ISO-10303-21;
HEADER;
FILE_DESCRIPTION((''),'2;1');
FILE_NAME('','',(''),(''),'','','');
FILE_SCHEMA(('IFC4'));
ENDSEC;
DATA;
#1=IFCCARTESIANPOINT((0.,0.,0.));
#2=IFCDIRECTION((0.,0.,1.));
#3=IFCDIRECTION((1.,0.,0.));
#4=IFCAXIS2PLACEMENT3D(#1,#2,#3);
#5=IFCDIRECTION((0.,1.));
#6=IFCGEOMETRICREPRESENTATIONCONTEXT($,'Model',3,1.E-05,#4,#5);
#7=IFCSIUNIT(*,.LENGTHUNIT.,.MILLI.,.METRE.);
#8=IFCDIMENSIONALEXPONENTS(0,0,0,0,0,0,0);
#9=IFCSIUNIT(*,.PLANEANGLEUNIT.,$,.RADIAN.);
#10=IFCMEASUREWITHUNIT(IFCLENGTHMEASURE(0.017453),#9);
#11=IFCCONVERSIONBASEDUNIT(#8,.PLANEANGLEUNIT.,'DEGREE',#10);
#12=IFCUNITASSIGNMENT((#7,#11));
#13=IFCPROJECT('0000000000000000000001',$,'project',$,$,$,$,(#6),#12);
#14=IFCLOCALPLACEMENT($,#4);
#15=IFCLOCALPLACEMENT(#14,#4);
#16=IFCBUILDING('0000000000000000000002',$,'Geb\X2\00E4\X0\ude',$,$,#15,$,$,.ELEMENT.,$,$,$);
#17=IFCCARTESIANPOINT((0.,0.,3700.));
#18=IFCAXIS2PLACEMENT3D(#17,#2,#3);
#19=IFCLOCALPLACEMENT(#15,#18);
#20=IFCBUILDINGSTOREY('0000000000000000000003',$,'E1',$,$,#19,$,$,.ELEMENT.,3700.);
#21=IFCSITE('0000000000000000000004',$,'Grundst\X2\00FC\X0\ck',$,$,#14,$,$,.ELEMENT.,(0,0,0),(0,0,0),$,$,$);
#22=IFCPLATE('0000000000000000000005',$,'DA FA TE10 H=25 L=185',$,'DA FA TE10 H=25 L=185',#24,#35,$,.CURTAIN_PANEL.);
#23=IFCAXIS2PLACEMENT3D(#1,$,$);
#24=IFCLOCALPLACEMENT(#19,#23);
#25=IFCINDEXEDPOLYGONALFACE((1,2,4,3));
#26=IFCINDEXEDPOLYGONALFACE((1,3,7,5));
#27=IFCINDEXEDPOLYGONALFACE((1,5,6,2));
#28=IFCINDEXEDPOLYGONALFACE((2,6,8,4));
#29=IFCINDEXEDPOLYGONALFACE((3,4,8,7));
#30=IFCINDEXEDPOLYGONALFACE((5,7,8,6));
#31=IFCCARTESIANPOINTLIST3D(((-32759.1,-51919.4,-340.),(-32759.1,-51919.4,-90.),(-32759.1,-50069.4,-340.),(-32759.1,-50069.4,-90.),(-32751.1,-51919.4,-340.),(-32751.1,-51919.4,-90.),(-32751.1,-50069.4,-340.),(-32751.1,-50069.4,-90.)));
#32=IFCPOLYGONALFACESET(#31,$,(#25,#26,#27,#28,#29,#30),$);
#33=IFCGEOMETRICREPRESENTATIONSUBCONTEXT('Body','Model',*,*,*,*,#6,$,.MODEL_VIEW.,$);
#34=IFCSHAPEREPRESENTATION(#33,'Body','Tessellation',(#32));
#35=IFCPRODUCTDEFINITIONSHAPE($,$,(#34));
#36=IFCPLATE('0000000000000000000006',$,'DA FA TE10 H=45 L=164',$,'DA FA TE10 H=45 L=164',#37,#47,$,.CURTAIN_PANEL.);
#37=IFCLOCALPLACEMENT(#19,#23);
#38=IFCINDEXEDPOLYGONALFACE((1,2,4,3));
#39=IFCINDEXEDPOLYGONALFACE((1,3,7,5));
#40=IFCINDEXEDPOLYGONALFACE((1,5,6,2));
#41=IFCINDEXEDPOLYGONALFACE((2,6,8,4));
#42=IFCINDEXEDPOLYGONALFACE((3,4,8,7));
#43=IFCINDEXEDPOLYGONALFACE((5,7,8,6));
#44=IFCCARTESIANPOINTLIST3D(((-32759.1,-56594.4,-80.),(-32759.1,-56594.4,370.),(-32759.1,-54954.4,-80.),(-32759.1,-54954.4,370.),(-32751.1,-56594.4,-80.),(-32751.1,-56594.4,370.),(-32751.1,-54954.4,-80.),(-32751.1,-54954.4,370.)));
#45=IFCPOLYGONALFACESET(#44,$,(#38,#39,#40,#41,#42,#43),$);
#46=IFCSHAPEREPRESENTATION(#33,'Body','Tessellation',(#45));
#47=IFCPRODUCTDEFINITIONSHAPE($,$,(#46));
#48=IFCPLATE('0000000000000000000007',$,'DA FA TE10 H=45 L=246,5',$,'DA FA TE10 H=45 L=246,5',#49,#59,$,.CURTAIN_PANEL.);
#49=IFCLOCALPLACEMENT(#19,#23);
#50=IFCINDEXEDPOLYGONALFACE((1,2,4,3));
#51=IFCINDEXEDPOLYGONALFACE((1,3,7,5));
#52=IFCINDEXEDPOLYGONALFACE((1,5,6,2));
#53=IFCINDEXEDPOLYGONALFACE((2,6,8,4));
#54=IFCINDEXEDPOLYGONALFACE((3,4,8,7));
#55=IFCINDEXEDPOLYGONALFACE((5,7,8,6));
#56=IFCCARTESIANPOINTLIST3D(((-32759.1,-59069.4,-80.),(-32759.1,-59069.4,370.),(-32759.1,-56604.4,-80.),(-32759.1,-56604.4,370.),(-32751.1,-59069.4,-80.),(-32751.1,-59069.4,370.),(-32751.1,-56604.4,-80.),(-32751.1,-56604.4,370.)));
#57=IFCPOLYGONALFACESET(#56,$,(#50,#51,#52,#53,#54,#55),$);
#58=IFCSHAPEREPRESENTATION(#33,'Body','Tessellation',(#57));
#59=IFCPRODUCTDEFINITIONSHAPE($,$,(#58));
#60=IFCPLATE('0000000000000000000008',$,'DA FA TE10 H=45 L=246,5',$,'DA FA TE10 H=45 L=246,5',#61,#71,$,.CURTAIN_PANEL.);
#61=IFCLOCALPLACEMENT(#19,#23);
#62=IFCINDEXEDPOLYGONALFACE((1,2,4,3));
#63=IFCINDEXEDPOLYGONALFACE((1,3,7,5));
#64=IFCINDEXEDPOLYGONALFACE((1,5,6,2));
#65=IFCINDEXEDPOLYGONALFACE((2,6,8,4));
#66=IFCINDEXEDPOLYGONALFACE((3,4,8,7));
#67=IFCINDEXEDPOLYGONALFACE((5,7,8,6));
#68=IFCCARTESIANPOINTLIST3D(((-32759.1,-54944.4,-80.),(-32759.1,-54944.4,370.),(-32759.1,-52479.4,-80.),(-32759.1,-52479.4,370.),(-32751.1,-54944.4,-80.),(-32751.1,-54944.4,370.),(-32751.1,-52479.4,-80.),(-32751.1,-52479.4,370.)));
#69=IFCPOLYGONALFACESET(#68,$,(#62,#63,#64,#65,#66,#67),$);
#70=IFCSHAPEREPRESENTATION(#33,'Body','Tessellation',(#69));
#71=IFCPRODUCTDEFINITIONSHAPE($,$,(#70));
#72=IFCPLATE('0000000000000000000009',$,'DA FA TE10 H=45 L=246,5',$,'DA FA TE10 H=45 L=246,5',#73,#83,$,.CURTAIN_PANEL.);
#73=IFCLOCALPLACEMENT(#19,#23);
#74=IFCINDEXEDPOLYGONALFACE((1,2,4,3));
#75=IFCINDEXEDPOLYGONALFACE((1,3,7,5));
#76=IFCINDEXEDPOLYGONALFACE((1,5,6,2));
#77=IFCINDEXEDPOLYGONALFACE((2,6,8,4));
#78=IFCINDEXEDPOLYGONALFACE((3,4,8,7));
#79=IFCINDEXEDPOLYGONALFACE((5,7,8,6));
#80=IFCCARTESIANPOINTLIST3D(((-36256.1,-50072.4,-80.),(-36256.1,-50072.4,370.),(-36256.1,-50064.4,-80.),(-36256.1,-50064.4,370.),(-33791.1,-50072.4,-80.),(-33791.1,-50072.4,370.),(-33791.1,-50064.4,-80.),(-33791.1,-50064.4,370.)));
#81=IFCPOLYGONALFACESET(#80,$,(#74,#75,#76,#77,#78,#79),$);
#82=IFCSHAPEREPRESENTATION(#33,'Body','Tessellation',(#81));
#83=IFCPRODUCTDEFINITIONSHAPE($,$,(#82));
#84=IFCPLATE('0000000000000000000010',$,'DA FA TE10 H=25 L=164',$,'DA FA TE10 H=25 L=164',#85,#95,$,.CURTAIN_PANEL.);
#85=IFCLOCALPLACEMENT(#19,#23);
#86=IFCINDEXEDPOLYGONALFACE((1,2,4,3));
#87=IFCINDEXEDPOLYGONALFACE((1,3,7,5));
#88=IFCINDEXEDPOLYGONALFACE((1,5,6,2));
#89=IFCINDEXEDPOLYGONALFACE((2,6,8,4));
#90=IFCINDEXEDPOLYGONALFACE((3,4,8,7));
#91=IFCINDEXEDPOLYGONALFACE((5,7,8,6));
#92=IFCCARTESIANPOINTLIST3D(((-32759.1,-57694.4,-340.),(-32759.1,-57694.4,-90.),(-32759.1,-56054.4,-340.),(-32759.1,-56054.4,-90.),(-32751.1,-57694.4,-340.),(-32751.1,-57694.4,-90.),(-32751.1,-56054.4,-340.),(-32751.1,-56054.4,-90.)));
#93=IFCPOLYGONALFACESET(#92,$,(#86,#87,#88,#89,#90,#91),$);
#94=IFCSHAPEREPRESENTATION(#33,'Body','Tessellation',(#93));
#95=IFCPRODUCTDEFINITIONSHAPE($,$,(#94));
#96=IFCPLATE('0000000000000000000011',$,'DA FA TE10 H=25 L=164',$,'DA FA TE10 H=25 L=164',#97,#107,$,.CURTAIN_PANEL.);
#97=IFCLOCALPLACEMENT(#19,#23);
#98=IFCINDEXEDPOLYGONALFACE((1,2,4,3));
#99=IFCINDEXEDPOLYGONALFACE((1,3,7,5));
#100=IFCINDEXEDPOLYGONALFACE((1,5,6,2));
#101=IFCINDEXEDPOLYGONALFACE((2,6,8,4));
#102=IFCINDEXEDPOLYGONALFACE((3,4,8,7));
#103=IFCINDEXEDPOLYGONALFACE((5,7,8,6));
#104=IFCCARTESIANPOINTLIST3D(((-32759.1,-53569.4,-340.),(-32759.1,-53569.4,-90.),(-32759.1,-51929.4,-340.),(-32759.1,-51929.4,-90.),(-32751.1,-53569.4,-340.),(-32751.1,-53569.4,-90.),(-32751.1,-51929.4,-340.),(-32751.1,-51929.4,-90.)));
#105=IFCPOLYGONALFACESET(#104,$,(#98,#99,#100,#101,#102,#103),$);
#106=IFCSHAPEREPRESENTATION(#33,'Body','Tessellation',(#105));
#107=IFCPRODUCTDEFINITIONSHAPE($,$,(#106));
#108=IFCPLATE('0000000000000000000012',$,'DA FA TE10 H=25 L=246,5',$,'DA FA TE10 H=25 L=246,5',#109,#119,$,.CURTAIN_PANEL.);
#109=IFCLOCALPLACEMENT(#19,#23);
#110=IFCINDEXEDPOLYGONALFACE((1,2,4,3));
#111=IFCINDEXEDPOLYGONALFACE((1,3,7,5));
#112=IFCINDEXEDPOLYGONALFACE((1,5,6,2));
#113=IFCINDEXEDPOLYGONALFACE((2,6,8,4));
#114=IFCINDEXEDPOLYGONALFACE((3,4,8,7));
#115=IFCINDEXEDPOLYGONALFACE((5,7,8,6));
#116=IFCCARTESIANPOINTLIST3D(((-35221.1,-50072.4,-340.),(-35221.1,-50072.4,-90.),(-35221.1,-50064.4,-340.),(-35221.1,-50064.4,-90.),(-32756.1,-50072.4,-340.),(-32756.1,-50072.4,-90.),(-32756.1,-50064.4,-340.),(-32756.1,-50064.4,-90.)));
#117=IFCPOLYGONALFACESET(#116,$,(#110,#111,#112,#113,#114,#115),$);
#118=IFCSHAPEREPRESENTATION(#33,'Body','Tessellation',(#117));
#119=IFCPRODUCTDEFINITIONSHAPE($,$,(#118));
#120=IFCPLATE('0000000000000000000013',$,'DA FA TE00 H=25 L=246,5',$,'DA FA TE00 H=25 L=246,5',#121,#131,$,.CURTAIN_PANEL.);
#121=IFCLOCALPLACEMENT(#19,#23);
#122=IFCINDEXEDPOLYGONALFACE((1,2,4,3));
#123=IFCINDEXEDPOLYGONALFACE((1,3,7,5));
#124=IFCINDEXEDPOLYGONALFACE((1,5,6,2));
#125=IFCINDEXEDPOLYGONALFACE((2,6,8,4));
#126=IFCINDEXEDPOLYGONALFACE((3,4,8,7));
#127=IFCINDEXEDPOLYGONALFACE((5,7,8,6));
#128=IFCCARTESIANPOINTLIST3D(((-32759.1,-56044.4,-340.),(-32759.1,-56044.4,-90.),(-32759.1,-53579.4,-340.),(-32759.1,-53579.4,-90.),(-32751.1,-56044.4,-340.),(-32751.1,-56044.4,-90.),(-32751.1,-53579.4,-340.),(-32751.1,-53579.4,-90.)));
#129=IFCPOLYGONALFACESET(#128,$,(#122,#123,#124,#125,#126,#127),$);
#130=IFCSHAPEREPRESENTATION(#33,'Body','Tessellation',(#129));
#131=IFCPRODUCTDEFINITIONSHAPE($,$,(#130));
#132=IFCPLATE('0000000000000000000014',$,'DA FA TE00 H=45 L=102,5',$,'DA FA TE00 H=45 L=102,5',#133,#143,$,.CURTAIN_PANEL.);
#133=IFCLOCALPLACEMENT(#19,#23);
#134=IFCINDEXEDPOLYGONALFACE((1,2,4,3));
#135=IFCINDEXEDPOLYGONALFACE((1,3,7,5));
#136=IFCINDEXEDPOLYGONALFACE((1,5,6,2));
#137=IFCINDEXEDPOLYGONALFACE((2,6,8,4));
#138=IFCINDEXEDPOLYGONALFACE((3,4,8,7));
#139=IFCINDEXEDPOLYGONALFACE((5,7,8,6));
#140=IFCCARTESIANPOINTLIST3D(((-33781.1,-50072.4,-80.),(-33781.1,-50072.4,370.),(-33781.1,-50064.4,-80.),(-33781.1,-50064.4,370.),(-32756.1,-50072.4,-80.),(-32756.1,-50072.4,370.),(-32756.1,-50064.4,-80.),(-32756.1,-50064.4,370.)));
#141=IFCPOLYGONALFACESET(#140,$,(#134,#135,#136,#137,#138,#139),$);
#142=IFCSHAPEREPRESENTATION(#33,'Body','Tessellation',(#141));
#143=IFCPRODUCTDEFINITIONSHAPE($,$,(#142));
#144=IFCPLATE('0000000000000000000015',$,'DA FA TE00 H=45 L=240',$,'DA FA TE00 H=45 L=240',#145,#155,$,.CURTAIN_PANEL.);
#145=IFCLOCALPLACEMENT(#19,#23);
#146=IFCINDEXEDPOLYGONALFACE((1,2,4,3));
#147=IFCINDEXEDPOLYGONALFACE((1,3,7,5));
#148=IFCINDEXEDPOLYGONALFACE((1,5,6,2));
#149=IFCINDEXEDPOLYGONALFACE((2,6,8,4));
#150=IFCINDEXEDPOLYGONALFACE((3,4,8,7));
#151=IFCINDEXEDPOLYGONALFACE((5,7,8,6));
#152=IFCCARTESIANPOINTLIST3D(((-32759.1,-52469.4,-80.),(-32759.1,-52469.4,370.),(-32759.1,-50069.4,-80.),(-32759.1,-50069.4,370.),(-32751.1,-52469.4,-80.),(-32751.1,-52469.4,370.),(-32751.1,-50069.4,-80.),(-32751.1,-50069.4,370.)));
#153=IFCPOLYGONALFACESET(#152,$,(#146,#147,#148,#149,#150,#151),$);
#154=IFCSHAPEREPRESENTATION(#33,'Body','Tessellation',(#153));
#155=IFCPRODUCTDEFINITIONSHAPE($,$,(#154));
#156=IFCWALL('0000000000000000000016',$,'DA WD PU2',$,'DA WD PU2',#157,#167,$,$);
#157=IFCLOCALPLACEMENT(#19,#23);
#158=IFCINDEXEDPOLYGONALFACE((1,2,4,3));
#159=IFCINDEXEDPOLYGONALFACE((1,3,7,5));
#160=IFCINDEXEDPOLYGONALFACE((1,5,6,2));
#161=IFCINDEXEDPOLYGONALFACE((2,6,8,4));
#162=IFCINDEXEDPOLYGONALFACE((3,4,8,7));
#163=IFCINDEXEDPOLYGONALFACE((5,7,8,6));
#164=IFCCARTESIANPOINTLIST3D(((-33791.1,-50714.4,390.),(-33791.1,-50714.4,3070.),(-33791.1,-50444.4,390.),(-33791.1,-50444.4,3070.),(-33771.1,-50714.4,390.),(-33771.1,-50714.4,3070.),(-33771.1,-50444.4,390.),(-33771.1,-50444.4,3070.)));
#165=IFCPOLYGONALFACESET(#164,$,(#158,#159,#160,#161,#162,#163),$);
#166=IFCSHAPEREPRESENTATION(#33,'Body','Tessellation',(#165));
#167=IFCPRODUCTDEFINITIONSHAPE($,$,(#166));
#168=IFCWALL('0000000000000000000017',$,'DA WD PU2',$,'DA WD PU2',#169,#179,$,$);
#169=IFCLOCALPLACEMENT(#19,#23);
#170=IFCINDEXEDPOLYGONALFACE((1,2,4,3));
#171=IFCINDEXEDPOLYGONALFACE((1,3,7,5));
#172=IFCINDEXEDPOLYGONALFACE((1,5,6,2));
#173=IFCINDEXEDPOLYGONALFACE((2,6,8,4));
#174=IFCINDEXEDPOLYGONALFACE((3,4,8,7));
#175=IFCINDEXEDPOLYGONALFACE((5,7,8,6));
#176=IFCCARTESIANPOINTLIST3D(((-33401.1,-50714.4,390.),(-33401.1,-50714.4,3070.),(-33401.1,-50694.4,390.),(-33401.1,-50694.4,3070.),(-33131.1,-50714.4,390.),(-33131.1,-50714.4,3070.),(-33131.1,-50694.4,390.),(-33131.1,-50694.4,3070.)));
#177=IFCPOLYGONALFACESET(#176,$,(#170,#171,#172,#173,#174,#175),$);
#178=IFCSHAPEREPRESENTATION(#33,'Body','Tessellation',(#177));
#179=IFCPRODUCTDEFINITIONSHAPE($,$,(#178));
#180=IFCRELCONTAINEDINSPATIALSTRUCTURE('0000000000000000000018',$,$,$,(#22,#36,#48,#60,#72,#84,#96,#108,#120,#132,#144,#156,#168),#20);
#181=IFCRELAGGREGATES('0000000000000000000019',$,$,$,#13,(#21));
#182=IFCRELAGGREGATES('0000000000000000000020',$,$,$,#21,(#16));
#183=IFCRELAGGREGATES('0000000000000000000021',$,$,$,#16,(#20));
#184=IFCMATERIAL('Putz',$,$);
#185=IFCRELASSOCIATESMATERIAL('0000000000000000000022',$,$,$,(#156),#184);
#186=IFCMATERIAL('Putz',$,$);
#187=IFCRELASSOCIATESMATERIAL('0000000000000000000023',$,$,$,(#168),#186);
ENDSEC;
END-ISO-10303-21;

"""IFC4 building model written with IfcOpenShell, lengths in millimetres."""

from ifc_helpers import new_model, entity, si_unit, converted_unit, direction, frame, origin_with_axes, place, context, subcontext, project, spatial, line, indexed_curve, outline, extrude, source, transform, mapped, material, element, save


model = new_model("IFC4")

# Units and contexts
model_context = context("Model", 3, precision=1e-05, world=origin_with_axes(), true_north=direction((0.0, 1.0)))
body_context = subcontext(model_context, "Body", "Model", "MODEL_VIEW")
ifc_project = project(units=[si_unit("LENGTHUNIT", "METRE", prefix="MILLI"), converted_unit("PLANEANGLEUNIT", "DEGREE", entity("IfcLengthMeasure", 0.017453), si_unit("PLANEANGLEUNIT", "RADIAN"), dimensions=[0, 0, 0, 0, 0, 0, 0])], contexts=[model_context])

# Site, building, storey
site_placement = place(None, origin_with_axes())
site = spatial("IfcSite", under=ifc_project, at=site_placement, Name="Grundstück", CompositionType="ELEMENT", RefLatitude=(0, 0, 0), RefLongitude=(0, 0, 0))
building_placement = place(site_placement, origin_with_axes())
building = spatial("IfcBuilding", under=site, at=building_placement, Name="Gebäude", CompositionType="ELEMENT")
storey_placement = place(building_placement, frame((0.0, 0.0, 3700.0), z_axis=(0.0, 0.0, 1.0), x_axis=(1.0, 0.0, 0.0)))
storey = spatial("IfcBuildingStorey", under=building, at=storey_placement, Name="E1", CompositionType="ELEMENT", Elevation=3700.0)

# Plates
shared_shape_1 = source(origin_with_axes(), body_context, "Body", "SweptSolid", [
    extrude(outline(indexed_curve([(-925.0, 0.0), (925.0, 0.0), (925.0, 8.0), (-925.0, 8.0)], segments=[line(1, 2), line(2, 3), line(3, 4), line(4, 1)])), frame((0.0, 0.0, 250.0), z_axis=(0.0, 0.0, 1.0), x_axis=(1.0, 0.0, 0.0)), (0.0, 0.0, -1.0), 250.0),
])
plate_1_placement = place(storey_placement, frame((-32751.1, -50994.4, -340.0), z_axis=(0.0, 0.0, 1.0), x_axis=(0.0, 1.0, 0.0)))
element("IfcPlate", 1, at=plate_1_placement, inside=storey, Name="DA FA TE10 H=25 L=185", ObjectType="DA FA TE10 H=25 L=185", PredefinedType="CURTAIN_PANEL", context=body_context, shape_type="MappedRepresentation", body=[
    mapped(shared_shape_1, transform((0.0, 0.0, 0.0), x_axis=(1.0, 0.0, 0.0), y_axis=(0.0, 1.0, 0.0), z_axis=(0.0, 0.0, 1.0), scale=1.0)),
])
shared_shape_2 = source(origin_with_axes(), body_context, "Body", "SweptSolid", [
    extrude(outline(indexed_curve([(-820.0, 0.0), (820.0, 0.0), (820.0, 8.0), (-820.0, 8.0)], segments=[line(1, 2), line(2, 3), line(3, 4), line(4, 1)])), frame((0.0, 0.0, 450.0), z_axis=(0.0, 0.0, 1.0), x_axis=(1.0, 0.0, 0.0)), (0.0, 0.0, -1.0), 450.0),
])
plate_2_placement = place(storey_placement, frame((-32751.1, -55774.4, -80.0), z_axis=(0.0, 0.0, 1.0), x_axis=(0.0, 1.0, 0.0)))
element("IfcPlate", 2, at=plate_2_placement, inside=storey, Name="DA FA TE10 H=45 L=164", ObjectType="DA FA TE10 H=45 L=164", PredefinedType="CURTAIN_PANEL", context=body_context, shape_type="MappedRepresentation", body=[
    mapped(shared_shape_2, transform((0.0, 0.0, 0.0), x_axis=(1.0, 0.0, 0.0), y_axis=(0.0, 1.0, 0.0), z_axis=(0.0, 0.0, 1.0), scale=1.0)),
])
shared_shape_3 = source(origin_with_axes(), body_context, "Body", "SweptSolid", [
    extrude(outline(indexed_curve([(-1232.5, 0.0), (1232.5, 0.0), (1232.5, 8.0), (-1232.5, 8.0)], segments=[line(1, 2), line(2, 3), line(3, 4), line(4, 1)])), frame((0.0, 0.0, 450.0), z_axis=(0.0, 0.0, 1.0), x_axis=(1.0, 0.0, 0.0)), (0.0, 0.0, -1.0), 450.0),
])
for number, where, z_axis, x_axis, name in (
    (3, (-32751.1, -57836.9, -80.0), (0.0, 0.0, 1.0), (0.0, 1.0, 0.0), "DA FA TE10 H=45 L=246,5"),
    (4, (-32751.1, -53711.9, -80.0), (0.0, 0.0, 1.0), (0.0, 1.0, 0.0), "DA FA TE10 H=45 L=246,5"),
    (5, (-35023.6, -50064.4, -80.0), (0.0, 0.0, 1.0), (-1.0, 0.0, 0.0), "DA FA TE10 H=45 L=246,5"),
):
    element("IfcPlate", number, at=place(storey_placement, frame(where, z_axis=z_axis, x_axis=x_axis)), inside=storey, Name=name, ObjectType="DA FA TE10 H=45 L=246,5", PredefinedType="CURTAIN_PANEL", context=body_context, shape_type="MappedRepresentation", body=[
        mapped(shared_shape_3, transform((0.0, 0.0, 0.0), x_axis=(1.0, 0.0, 0.0), y_axis=(0.0, 1.0, 0.0), z_axis=(0.0, 0.0, 1.0), scale=1.0)),
    ])
shared_shape_4 = source(origin_with_axes(), body_context, "Body", "SweptSolid", [
    extrude(outline(indexed_curve([(-820.0, 0.0), (820.0, 0.0), (820.0, 8.0), (-820.0, 8.0)], segments=[line(1, 2), line(2, 3), line(3, 4), line(4, 1)])), frame((0.0, 0.0, 250.0), z_axis=(0.0, 0.0, 1.0), x_axis=(1.0, 0.0, 0.0)), (0.0, 0.0, -1.0), 250.0),
])
for number, where, z_axis, x_axis, name in (
    (6, (-32751.1, -56874.4, -340.0), (0.0, 0.0, 1.0), (0.0, 1.0, 0.0), "DA FA TE10 H=25 L=164"),
    (7, (-32751.1, -52749.4, -340.0), (0.0, 0.0, 1.0), (0.0, 1.0, 0.0), "DA FA TE10 H=25 L=164"),
):
    element("IfcPlate", number, at=place(storey_placement, frame(where, z_axis=z_axis, x_axis=x_axis)), inside=storey, Name=name, ObjectType="DA FA TE10 H=25 L=164", PredefinedType="CURTAIN_PANEL", context=body_context, shape_type="MappedRepresentation", body=[
        mapped(shared_shape_4, transform((0.0, 0.0, 0.0), x_axis=(1.0, 0.0, 0.0), y_axis=(0.0, 1.0, 0.0), z_axis=(0.0, 0.0, 1.0), scale=1.0)),
    ])
shared_shape_5 = source(origin_with_axes(), body_context, "Body", "SweptSolid", [
    extrude(outline(indexed_curve([(-1232.5, 0.0), (1232.5, 0.0), (1232.5, 8.0), (-1232.5, 8.0)], segments=[line(1, 2), line(2, 3), line(3, 4), line(4, 1)])), frame((0.0, 0.0, 250.0), z_axis=(0.0, 0.0, 1.0), x_axis=(1.0, 0.0, 0.0)), (0.0, 0.0, -1.0), 250.0),
])
plate_3_placement = place(storey_placement, frame((-33988.6, -50064.4, -340.0), z_axis=(0.0, 0.0, 1.0), x_axis=(-1.0, 0.0, 0.0)))
element("IfcPlate", 8, at=plate_3_placement, inside=storey, Name="DA FA TE10 H=25 L=246,5", ObjectType="DA FA TE10 H=25 L=246,5", PredefinedType="CURTAIN_PANEL", context=body_context, shape_type="MappedRepresentation", body=[
    mapped(shared_shape_5, transform((0.0, 0.0, 0.0), x_axis=(1.0, 0.0, 0.0), y_axis=(0.0, 1.0, 0.0), z_axis=(0.0, 0.0, 1.0), scale=1.0)),
])
shared_shape_6 = source(origin_with_axes(), body_context, "Body", "SweptSolid", [
    extrude(outline(indexed_curve([(-1232.5, 0.0), (1232.5, 0.0), (1232.5, 8.0), (-1232.5, 8.0)], segments=[line(1, 2), line(2, 3), line(3, 4), line(4, 1)])), frame((0.0, 0.0, 250.0), z_axis=(0.0, 0.0, 1.0), x_axis=(1.0, 0.0, 0.0)), (0.0, 0.0, -1.0), 250.0),
])
plate_4_placement = place(storey_placement, frame((-32751.1, -54811.9, -340.0), z_axis=(0.0, 0.0, 1.0), x_axis=(0.0, 1.0, 0.0)))
element("IfcPlate", 9, at=plate_4_placement, inside=storey, Name="DA FA TE00 H=25 L=246,5", ObjectType="DA FA TE00 H=25 L=246,5", PredefinedType="CURTAIN_PANEL", context=body_context, shape_type="MappedRepresentation", body=[
    mapped(shared_shape_6, transform((0.0, 0.0, 0.0), x_axis=(1.0, 0.0, 0.0), y_axis=(0.0, 1.0, 0.0), z_axis=(0.0, 0.0, 1.0), scale=1.0)),
])
shared_shape_7 = source(origin_with_axes(), body_context, "Body", "SweptSolid", [
    extrude(outline(indexed_curve([(-512.5, 0.0), (512.5, 0.0), (512.5, 8.0), (-512.5, 8.0)], segments=[line(1, 2), line(2, 3), line(3, 4), line(4, 1)])), frame((0.0, 0.0, 450.0), z_axis=(0.0, 0.0, 1.0), x_axis=(1.0, 0.0, 0.0)), (0.0, 0.0, -1.0), 450.0),
])
plate_5_placement = place(storey_placement, frame((-33268.6, -50064.4, -80.0), z_axis=(0.0, 0.0, 1.0), x_axis=(-1.0, 0.0, 0.0)))
element("IfcPlate", 10, at=plate_5_placement, inside=storey, Name="DA FA TE00 H=45 L=102,5", ObjectType="DA FA TE00 H=45 L=102,5", PredefinedType="CURTAIN_PANEL", context=body_context, shape_type="MappedRepresentation", body=[
    mapped(shared_shape_7, transform((0.0, 0.0, 0.0), x_axis=(1.0, 0.0, 0.0), y_axis=(0.0, 1.0, 0.0), z_axis=(0.0, 0.0, 1.0), scale=1.0)),
])
plate_6_placement = place(storey_placement, frame((-32751.1, -51269.4, -80.0), z_axis=(0.0, 0.0, 1.0), x_axis=(0.0, 1.0, 0.0)))
element("IfcPlate", 11, at=plate_6_placement, inside=storey, Name="DA FA TE00 H=45 L=240", ObjectType="DA FA TE00 H=45 L=240", PredefinedType="CURTAIN_PANEL", context=body_context, shape_type="SweptSolid", body=[
    extrude(outline(indexed_curve([(-1200.0, 0.0), (1200.0, 0.0), (1200.0, 8.0), (-1200.0, 8.0)], segments=[line(1, 2), line(2, 3), line(3, 4), line(4, 1)])), frame((0.0, 0.0, 450.0), z_axis=(0.0, 0.0, 1.0), x_axis=(1.0, 0.0, 0.0)), (0.0, 0.0, -1.0), 450.0),
])

# Walls
ifc_material_1 = material(Name="Putz")
wall_1_placement = place(storey_placement, frame((-33781.1, -50444.4, 390.0), z_axis=(0.0, 0.0, 1.0), x_axis=(0.0, -1.0, 0.0)))
element("IfcWall", 12, at=wall_1_placement, inside=storey, material=ifc_material_1, Name="DA WD PU2", ObjectType="DA WD PU2", context=body_context, shape_type="SweptSolid", body=[
    extrude(outline(indexed_curve([(0.0, -10.0), (0.0, 10.0), (270.0, 10.0), (270.0, -10.0)], segments=[line(1, 2), line(2, 3), line(3, 4), line(4, 1)])), origin_with_axes(), (0.0, 0.0, 1.0), 2680.0),
])
ifc_material_2 = material(Name="Putz")
wall_2_placement = place(storey_placement, frame((-33401.1, -50704.4, 390.0), z_axis=(0.0, 0.0, 1.0), x_axis=(1.0, 0.0, 0.0)))
element("IfcWall", 13, at=wall_2_placement, inside=storey, material=ifc_material_2, Name="DA WD PU2", ObjectType="DA WD PU2", context=body_context, shape_type="SweptSolid", body=[
    extrude(outline(indexed_curve([(0.0, -10.0), (0.0, 10.0), (270.0, 10.0), (270.0, -10.0)], segments=[line(1, 2), line(2, 3), line(3, 4), line(4, 1)])), origin_with_axes(), (0.0, 0.0, 1.0), 2680.0),
])

save(model, "model.ifc")
